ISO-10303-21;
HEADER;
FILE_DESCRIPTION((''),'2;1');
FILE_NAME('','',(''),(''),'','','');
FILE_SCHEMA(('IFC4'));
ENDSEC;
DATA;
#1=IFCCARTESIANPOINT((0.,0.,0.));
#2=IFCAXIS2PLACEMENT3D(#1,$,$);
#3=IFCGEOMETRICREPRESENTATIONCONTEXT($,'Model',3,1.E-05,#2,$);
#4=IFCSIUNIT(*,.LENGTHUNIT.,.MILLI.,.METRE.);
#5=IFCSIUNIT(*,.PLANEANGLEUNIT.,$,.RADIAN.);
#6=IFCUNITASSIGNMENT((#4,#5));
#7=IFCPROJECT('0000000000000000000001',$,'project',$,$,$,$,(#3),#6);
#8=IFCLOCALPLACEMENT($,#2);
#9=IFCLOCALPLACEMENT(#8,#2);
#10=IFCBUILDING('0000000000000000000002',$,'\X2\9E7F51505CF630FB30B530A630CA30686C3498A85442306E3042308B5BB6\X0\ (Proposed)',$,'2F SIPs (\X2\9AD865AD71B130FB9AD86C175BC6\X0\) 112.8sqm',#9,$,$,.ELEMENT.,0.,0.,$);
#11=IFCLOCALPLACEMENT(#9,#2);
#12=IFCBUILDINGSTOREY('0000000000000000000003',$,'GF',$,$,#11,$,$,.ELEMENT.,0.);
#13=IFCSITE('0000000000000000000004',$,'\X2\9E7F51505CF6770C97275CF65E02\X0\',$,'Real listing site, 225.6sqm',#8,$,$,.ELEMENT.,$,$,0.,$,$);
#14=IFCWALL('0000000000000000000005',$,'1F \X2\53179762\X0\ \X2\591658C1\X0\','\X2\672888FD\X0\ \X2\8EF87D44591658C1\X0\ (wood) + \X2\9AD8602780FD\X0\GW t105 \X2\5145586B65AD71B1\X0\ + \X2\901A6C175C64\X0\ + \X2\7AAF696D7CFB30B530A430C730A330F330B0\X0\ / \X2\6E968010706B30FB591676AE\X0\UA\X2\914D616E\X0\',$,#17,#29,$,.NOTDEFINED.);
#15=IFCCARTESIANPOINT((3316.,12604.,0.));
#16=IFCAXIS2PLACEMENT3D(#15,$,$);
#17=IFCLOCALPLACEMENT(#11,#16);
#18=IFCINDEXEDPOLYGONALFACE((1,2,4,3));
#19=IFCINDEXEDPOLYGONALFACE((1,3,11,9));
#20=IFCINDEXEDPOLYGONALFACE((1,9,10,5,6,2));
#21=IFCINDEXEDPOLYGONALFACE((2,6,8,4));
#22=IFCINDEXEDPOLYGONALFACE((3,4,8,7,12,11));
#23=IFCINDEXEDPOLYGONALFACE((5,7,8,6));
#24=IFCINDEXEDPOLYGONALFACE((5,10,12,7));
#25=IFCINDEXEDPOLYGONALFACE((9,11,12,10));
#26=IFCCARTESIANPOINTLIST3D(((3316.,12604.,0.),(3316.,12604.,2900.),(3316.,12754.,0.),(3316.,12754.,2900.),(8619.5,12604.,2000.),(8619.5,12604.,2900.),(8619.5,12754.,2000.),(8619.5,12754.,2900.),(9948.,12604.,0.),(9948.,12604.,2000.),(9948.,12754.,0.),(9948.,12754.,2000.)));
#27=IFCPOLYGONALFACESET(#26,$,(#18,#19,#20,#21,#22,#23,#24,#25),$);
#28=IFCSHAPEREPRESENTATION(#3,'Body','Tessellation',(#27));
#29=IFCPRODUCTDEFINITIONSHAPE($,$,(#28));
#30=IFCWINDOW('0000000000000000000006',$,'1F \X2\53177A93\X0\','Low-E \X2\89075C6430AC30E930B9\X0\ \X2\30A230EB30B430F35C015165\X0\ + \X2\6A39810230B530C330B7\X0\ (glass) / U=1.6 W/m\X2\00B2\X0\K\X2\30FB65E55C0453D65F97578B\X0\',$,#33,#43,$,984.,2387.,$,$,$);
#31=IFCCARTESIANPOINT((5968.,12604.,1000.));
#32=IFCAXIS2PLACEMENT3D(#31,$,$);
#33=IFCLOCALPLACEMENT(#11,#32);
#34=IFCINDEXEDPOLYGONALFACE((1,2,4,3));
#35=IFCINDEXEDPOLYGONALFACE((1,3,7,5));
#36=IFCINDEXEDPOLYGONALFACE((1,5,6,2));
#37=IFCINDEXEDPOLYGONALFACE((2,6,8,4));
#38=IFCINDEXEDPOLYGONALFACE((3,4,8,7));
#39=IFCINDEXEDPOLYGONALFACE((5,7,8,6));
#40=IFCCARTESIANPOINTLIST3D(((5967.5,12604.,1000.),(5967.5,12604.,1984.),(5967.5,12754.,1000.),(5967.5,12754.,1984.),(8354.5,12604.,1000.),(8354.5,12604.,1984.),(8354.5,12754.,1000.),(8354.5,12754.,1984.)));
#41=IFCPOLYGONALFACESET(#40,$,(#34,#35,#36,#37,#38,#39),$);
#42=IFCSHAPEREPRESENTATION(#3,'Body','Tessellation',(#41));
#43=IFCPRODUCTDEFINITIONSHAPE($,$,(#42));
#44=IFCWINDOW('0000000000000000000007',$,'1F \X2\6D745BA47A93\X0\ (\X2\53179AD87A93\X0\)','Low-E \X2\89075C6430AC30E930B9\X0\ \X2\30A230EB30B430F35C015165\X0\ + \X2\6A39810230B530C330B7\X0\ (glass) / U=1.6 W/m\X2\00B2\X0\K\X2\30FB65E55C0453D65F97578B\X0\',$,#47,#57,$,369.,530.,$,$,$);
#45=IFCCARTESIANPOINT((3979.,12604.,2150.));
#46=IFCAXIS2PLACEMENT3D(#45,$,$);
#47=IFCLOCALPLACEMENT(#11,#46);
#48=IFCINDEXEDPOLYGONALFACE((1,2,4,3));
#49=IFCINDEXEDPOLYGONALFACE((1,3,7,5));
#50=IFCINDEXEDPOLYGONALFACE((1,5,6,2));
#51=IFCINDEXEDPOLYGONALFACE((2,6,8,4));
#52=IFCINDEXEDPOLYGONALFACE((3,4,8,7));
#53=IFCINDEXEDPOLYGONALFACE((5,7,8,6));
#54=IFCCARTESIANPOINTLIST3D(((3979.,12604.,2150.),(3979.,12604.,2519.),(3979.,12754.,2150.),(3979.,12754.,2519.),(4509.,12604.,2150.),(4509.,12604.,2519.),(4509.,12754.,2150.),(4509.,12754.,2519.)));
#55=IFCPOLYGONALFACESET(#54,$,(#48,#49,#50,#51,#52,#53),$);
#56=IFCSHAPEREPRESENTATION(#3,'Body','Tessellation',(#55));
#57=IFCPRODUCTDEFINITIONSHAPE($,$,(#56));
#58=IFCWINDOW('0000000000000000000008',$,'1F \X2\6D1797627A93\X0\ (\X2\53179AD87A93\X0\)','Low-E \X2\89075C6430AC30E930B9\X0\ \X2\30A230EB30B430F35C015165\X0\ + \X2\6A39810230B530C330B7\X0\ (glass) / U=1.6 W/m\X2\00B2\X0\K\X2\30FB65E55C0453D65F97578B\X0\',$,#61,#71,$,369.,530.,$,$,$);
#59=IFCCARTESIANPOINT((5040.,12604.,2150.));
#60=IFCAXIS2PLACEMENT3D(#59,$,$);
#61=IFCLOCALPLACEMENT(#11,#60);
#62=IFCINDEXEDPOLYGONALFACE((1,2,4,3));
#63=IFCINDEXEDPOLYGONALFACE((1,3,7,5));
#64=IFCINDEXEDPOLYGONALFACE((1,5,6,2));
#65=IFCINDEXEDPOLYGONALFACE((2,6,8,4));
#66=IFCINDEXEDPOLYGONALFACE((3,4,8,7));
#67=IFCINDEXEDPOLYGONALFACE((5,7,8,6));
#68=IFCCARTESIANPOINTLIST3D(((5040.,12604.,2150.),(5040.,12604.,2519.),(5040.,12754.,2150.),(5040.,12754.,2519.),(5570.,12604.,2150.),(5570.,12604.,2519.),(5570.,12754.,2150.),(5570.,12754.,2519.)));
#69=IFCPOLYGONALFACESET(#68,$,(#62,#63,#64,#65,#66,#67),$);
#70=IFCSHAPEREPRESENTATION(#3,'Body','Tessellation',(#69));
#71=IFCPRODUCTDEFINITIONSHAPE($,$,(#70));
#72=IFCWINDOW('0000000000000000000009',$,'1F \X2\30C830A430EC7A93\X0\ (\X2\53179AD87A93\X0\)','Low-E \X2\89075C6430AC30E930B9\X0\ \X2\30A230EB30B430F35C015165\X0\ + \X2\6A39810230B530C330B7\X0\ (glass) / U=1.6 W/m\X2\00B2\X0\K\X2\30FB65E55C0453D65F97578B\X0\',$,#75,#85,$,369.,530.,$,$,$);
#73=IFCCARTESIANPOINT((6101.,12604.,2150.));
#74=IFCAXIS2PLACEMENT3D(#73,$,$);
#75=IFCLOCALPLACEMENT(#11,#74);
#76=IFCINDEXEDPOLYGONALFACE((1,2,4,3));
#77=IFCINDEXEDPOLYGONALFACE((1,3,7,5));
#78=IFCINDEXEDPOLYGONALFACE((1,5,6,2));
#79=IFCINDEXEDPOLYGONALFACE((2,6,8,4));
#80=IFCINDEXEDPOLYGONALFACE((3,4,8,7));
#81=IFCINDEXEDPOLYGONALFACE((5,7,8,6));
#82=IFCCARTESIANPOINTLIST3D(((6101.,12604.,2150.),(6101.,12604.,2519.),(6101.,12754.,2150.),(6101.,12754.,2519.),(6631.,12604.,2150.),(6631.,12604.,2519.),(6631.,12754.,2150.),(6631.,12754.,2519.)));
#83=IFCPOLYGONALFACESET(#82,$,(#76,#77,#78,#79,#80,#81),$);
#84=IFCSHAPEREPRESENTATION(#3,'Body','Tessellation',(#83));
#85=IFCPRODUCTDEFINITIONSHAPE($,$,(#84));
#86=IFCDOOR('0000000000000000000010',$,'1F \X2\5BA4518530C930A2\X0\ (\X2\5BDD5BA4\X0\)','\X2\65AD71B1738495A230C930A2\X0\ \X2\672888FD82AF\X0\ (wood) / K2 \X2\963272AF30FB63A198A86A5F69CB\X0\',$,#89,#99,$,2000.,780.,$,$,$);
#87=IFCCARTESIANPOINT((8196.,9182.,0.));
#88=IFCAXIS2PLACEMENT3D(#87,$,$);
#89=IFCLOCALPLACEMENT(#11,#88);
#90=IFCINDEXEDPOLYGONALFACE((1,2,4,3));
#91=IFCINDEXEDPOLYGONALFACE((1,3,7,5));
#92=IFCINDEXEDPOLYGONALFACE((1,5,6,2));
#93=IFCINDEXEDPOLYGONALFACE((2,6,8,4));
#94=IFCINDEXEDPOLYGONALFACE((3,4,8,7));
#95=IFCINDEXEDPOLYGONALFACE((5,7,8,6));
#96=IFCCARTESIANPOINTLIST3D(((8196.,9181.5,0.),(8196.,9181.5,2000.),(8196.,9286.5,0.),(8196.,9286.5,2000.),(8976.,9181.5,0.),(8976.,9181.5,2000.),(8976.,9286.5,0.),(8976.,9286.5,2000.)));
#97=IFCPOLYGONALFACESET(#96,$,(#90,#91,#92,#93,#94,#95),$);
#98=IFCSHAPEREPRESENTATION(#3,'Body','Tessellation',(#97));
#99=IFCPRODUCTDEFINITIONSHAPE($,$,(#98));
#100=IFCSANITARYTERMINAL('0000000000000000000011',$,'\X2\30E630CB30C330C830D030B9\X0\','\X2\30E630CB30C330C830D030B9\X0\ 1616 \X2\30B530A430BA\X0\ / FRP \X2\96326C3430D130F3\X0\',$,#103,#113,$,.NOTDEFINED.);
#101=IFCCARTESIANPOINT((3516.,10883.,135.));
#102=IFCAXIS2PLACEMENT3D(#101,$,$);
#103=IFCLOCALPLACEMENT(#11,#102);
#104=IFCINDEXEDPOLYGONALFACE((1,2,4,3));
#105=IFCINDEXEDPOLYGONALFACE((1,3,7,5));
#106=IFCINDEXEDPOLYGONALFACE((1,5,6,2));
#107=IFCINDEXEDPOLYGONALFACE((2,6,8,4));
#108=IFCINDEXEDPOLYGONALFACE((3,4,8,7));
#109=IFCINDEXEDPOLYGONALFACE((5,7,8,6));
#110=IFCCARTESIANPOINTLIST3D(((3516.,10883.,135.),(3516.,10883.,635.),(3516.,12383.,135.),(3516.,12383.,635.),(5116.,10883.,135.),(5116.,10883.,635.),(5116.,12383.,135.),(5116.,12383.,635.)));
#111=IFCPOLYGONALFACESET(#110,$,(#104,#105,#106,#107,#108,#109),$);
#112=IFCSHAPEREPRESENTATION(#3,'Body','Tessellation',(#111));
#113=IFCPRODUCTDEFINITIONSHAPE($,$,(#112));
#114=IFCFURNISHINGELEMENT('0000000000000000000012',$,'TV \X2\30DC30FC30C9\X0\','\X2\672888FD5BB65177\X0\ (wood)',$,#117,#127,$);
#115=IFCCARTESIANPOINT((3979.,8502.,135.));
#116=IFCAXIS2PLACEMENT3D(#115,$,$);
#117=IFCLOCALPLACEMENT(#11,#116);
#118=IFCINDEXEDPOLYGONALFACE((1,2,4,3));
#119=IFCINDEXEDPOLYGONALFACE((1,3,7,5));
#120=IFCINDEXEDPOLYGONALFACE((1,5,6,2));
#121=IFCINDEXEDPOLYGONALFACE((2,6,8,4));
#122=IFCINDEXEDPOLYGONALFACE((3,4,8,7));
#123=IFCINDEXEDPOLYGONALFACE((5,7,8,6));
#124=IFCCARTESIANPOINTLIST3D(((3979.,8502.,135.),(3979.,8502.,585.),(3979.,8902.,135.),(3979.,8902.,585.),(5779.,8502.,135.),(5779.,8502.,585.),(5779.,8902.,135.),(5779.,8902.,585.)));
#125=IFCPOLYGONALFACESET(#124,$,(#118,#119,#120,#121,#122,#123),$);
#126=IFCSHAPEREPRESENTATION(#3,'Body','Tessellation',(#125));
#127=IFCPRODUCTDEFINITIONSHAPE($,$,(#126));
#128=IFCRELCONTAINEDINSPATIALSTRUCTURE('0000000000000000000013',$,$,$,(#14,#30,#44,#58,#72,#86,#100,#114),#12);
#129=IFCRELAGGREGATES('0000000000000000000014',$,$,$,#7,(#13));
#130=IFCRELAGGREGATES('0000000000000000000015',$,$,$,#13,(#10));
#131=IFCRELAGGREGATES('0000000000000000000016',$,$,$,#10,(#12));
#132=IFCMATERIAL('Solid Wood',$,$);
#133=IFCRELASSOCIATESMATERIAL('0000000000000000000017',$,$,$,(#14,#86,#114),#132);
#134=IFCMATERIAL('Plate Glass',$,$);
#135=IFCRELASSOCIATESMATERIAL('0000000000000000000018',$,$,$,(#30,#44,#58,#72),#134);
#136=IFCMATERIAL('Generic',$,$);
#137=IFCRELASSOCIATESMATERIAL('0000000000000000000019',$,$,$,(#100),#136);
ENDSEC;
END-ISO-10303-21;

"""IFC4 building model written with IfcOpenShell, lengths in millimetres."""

from ifc_helpers import new_model, si_unit, frame, frame_2d, origin, place, context, project, spatial, rectangle, extrude, material, element, fill, save


model = new_model("IFC4")

# Units and contexts
model_context = context("Model", 3, precision=1e-05, world=origin())
ifc_project = project(units=[si_unit("LENGTHUNIT", "METRE", prefix="MILLI"), si_unit("PLANEANGLEUNIT", "RADIAN")], contexts=[model_context])

# Site, building, storey
site_placement = place(None, origin())
site = spatial("IfcSite", under=ifc_project, at=site_placement, Name="鹿児島県霧島市", ObjectType="Real listing site, 225.6sqm", CompositionType="ELEMENT", RefElevation=0.0)
building_placement = place(site_placement, origin())
building = spatial("IfcBuilding", under=site, at=building_placement, Name="鹿児島・サウナと水風呂のある家 (Proposed)", ObjectType="2F SIPs (高断熱・高気密) 112.8sqm", CompositionType="ELEMENT", ElevationOfRefHeight=0.0, ElevationOfTerrain=0.0)
storey_placement = place(building_placement, origin())
storey = spatial("IfcBuildingStorey", under=building, at=storey_placement, Name="GF", CompositionType="ELEMENT", Elevation=0.0)

# Wall, openings, windows
ifc_material_1 = material(Name="Solid Wood")
wall_1_placement = place(storey_placement, frame((3316.0, 12604.0, 0.0)))
wall_1 = element("IfcWall", 1, at=wall_1_placement, inside=storey, material=ifc_material_1, Name="1F 北面 外壁", Description="木製 軸組外壁 (wood) + 高性能GW t105 充填断熱 + 通気層 + 窯業系サイディング / 準耐火・外皮UA配慮", PredefinedType="NOTDEFINED", context=model_context, shape_type="SweptSolid", body=[
    extrude(rectangle(XDim=6632.0, YDim=150.0, at=frame_2d((3316.0, 75.0))), frame((3316.0, 12604.0, 0.0)), (0.0, 0.0, 1.0), 2900.0),
])
opening_1_placement = place(storey_placement, frame((5968.0, 12604.0, 1000.0)))
opening_1 = element("IfcOpeningElement", 2, at=opening_1_placement, cuts=wall_1, PredefinedType="NOTDEFINED", context=model_context, shape_type="SweptSolid", body=[
    extrude(rectangle(XDim=2387.0, YDim=150.0, at=frame_2d((1193.0, 75.0))), frame((5968.0, 12604.0, 1000.0)), (0.0, 0.0, 1.0), 984.0),
])
opening_2_placement = place(storey_placement, frame((3979.0, 12604.0, 2150.0)))
opening_2 = element("IfcOpeningElement", 3, at=opening_2_placement, cuts=wall_1, PredefinedType="NOTDEFINED", context=model_context, shape_type="SweptSolid", body=[
    extrude(rectangle(XDim=530.0, YDim=150.0, at=frame_2d((265.0, 75.0))), frame((3979.0, 12604.0, 2150.0)), (0.0, 0.0, 1.0), 369.0),
])
opening_3_placement = place(storey_placement, frame((5040.0, 12604.0, 2150.0)))
opening_3 = element("IfcOpeningElement", 4, at=opening_3_placement, cuts=wall_1, PredefinedType="NOTDEFINED", context=model_context, shape_type="SweptSolid", body=[
    extrude(rectangle(XDim=530.0, YDim=150.0, at=frame_2d((265.0, 75.0))), frame((5040.0, 12604.0, 2150.0)), (0.0, 0.0, 1.0), 369.0),
])
opening_4_placement = place(storey_placement, frame((6101.0, 12604.0, 2150.0)))
opening_4 = element("IfcOpeningElement", 5, at=opening_4_placement, cuts=wall_1, PredefinedType="NOTDEFINED", context=model_context, shape_type="SweptSolid", body=[
    extrude(rectangle(XDim=530.0, YDim=150.0, at=frame_2d((265.0, 75.0))), frame((6101.0, 12604.0, 2150.0)), (0.0, 0.0, 1.0), 369.0),
])
ifc_material_2 = material(Name="Plate Glass")
window_1_placement = place(storey_placement, frame((5968.0, 12604.0, 1000.0)))
window_1 = element("IfcWindow", 6, at=window_1_placement, inside=storey, material=ifc_material_2, Name="1F 北窓", Description="Low-E 複層ガラス アルゴン封入 + 樹脂サッシ (glass) / U=1.6 W/m²K・日射取得型", OverallHeight=984.0, OverallWidth=2387.0, context=model_context, shape_type="SweptSolid", body=[
    extrude(rectangle(XDim=2387.0, YDim=150.0, at=frame_2d((1193.0, 75.0))), frame((5968.0, 12604.0, 1000.0)), (0.0, 0.0, 1.0), 984.0),
])
fill(opening_1, window_1)
window_2_placement = place(storey_placement, frame((3979.0, 12604.0, 2150.0)))
window_2 = element("IfcWindow", 7, at=window_2_placement, inside=storey, material=ifc_material_2, Name="1F 浴室窓 (北高窓)", Description="Low-E 複層ガラス アルゴン封入 + 樹脂サッシ (glass) / U=1.6 W/m²K・日射取得型", OverallHeight=369.0, OverallWidth=530.0, context=model_context, shape_type="SweptSolid", body=[
    extrude(rectangle(XDim=530.0, YDim=150.0, at=frame_2d((265.0, 75.0))), frame((3979.0, 12604.0, 2150.0)), (0.0, 0.0, 1.0), 369.0),
])
fill(opening_2, window_2)
window_3_placement = place(storey_placement, frame((5040.0, 12604.0, 2150.0)))
window_3 = element("IfcWindow", 8, at=window_3_placement, inside=storey, material=ifc_material_2, Name="1F 洗面窓 (北高窓)", Description="Low-E 複層ガラス アルゴン封入 + 樹脂サッシ (glass) / U=1.6 W/m²K・日射取得型", OverallHeight=369.0, OverallWidth=530.0, context=model_context, shape_type="SweptSolid", body=[
    extrude(rectangle(XDim=530.0, YDim=150.0, at=frame_2d((265.0, 75.0))), frame((5040.0, 12604.0, 2150.0)), (0.0, 0.0, 1.0), 369.0),
])
fill(opening_3, window_3)
window_4_placement = place(storey_placement, frame((6101.0, 12604.0, 2150.0)))
window_4 = element("IfcWindow", 9, at=window_4_placement, inside=storey, material=ifc_material_2, Name="1F トイレ窓 (北高窓)", Description="Low-E 複層ガラス アルゴン封入 + 樹脂サッシ (glass) / U=1.6 W/m²K・日射取得型", OverallHeight=369.0, OverallWidth=530.0, context=model_context, shape_type="SweptSolid", body=[
    extrude(rectangle(XDim=530.0, YDim=150.0, at=frame_2d((265.0, 75.0))), frame((6101.0, 12604.0, 2150.0)), (0.0, 0.0, 1.0), 369.0),
])
fill(opening_4, window_4)

# Door
door_1_placement = place(storey_placement, frame((8196.0, 9182.0, 0.0)))
element("IfcDoor", 10, at=door_1_placement, inside=storey, material=ifc_material_1, Name="1F 室内ドア (寝室)", Description="断熱玄関ドア 木製芯 (wood) / K2 防犯・採風機構", OverallHeight=2000.0, OverallWidth=780.0, context=model_context, shape_type="SweptSolid", body=[
    extrude(rectangle(XDim=780.0, YDim=105.0, at=frame_2d((390.0, 52.0))), frame((8196.0, 9182.0, 0.0)), (0.0, 0.0, 1.0), 2000.0),
])

# Sanitary terminal
ifc_material_3 = material(Name="Generic")
sanitary_terminal_placement = place(storey_placement, frame((3516.0, 10883.0, 135.0)))
element("IfcSanitaryTerminal", 11, at=sanitary_terminal_placement, inside=storey, material=ifc_material_3, Name="ユニットバス", Description="ユニットバス 1616 サイズ / FRP 防水パン", PredefinedType="NOTDEFINED", context=model_context, shape_type="SweptSolid", body=[
    extrude(rectangle(XDim=1600.0, YDim=1500.0, at=frame_2d((800.0, 750.0))), frame((3516.0, 10883.0, 135.0)), (0.0, 0.0, 1.0), 500.0),
])

# Furnishing element
furnishing_placement = place(storey_placement, frame((3979.0, 8502.0, 135.0)))
element("IfcFurnishingElement", 12, at=furnishing_placement, inside=storey, material=ifc_material_1, Name="TV ボード", Description="木製家具 (wood)", context=model_context, shape_type="SweptSolid", body=[
    extrude(rectangle(XDim=1800.0, YDim=400.0, at=frame_2d((900.0, 200.0))), frame((3979.0, 8502.0, 135.0)), (0.0, 0.0, 1.0), 450.0),
])

save(model, "model.ifc")
